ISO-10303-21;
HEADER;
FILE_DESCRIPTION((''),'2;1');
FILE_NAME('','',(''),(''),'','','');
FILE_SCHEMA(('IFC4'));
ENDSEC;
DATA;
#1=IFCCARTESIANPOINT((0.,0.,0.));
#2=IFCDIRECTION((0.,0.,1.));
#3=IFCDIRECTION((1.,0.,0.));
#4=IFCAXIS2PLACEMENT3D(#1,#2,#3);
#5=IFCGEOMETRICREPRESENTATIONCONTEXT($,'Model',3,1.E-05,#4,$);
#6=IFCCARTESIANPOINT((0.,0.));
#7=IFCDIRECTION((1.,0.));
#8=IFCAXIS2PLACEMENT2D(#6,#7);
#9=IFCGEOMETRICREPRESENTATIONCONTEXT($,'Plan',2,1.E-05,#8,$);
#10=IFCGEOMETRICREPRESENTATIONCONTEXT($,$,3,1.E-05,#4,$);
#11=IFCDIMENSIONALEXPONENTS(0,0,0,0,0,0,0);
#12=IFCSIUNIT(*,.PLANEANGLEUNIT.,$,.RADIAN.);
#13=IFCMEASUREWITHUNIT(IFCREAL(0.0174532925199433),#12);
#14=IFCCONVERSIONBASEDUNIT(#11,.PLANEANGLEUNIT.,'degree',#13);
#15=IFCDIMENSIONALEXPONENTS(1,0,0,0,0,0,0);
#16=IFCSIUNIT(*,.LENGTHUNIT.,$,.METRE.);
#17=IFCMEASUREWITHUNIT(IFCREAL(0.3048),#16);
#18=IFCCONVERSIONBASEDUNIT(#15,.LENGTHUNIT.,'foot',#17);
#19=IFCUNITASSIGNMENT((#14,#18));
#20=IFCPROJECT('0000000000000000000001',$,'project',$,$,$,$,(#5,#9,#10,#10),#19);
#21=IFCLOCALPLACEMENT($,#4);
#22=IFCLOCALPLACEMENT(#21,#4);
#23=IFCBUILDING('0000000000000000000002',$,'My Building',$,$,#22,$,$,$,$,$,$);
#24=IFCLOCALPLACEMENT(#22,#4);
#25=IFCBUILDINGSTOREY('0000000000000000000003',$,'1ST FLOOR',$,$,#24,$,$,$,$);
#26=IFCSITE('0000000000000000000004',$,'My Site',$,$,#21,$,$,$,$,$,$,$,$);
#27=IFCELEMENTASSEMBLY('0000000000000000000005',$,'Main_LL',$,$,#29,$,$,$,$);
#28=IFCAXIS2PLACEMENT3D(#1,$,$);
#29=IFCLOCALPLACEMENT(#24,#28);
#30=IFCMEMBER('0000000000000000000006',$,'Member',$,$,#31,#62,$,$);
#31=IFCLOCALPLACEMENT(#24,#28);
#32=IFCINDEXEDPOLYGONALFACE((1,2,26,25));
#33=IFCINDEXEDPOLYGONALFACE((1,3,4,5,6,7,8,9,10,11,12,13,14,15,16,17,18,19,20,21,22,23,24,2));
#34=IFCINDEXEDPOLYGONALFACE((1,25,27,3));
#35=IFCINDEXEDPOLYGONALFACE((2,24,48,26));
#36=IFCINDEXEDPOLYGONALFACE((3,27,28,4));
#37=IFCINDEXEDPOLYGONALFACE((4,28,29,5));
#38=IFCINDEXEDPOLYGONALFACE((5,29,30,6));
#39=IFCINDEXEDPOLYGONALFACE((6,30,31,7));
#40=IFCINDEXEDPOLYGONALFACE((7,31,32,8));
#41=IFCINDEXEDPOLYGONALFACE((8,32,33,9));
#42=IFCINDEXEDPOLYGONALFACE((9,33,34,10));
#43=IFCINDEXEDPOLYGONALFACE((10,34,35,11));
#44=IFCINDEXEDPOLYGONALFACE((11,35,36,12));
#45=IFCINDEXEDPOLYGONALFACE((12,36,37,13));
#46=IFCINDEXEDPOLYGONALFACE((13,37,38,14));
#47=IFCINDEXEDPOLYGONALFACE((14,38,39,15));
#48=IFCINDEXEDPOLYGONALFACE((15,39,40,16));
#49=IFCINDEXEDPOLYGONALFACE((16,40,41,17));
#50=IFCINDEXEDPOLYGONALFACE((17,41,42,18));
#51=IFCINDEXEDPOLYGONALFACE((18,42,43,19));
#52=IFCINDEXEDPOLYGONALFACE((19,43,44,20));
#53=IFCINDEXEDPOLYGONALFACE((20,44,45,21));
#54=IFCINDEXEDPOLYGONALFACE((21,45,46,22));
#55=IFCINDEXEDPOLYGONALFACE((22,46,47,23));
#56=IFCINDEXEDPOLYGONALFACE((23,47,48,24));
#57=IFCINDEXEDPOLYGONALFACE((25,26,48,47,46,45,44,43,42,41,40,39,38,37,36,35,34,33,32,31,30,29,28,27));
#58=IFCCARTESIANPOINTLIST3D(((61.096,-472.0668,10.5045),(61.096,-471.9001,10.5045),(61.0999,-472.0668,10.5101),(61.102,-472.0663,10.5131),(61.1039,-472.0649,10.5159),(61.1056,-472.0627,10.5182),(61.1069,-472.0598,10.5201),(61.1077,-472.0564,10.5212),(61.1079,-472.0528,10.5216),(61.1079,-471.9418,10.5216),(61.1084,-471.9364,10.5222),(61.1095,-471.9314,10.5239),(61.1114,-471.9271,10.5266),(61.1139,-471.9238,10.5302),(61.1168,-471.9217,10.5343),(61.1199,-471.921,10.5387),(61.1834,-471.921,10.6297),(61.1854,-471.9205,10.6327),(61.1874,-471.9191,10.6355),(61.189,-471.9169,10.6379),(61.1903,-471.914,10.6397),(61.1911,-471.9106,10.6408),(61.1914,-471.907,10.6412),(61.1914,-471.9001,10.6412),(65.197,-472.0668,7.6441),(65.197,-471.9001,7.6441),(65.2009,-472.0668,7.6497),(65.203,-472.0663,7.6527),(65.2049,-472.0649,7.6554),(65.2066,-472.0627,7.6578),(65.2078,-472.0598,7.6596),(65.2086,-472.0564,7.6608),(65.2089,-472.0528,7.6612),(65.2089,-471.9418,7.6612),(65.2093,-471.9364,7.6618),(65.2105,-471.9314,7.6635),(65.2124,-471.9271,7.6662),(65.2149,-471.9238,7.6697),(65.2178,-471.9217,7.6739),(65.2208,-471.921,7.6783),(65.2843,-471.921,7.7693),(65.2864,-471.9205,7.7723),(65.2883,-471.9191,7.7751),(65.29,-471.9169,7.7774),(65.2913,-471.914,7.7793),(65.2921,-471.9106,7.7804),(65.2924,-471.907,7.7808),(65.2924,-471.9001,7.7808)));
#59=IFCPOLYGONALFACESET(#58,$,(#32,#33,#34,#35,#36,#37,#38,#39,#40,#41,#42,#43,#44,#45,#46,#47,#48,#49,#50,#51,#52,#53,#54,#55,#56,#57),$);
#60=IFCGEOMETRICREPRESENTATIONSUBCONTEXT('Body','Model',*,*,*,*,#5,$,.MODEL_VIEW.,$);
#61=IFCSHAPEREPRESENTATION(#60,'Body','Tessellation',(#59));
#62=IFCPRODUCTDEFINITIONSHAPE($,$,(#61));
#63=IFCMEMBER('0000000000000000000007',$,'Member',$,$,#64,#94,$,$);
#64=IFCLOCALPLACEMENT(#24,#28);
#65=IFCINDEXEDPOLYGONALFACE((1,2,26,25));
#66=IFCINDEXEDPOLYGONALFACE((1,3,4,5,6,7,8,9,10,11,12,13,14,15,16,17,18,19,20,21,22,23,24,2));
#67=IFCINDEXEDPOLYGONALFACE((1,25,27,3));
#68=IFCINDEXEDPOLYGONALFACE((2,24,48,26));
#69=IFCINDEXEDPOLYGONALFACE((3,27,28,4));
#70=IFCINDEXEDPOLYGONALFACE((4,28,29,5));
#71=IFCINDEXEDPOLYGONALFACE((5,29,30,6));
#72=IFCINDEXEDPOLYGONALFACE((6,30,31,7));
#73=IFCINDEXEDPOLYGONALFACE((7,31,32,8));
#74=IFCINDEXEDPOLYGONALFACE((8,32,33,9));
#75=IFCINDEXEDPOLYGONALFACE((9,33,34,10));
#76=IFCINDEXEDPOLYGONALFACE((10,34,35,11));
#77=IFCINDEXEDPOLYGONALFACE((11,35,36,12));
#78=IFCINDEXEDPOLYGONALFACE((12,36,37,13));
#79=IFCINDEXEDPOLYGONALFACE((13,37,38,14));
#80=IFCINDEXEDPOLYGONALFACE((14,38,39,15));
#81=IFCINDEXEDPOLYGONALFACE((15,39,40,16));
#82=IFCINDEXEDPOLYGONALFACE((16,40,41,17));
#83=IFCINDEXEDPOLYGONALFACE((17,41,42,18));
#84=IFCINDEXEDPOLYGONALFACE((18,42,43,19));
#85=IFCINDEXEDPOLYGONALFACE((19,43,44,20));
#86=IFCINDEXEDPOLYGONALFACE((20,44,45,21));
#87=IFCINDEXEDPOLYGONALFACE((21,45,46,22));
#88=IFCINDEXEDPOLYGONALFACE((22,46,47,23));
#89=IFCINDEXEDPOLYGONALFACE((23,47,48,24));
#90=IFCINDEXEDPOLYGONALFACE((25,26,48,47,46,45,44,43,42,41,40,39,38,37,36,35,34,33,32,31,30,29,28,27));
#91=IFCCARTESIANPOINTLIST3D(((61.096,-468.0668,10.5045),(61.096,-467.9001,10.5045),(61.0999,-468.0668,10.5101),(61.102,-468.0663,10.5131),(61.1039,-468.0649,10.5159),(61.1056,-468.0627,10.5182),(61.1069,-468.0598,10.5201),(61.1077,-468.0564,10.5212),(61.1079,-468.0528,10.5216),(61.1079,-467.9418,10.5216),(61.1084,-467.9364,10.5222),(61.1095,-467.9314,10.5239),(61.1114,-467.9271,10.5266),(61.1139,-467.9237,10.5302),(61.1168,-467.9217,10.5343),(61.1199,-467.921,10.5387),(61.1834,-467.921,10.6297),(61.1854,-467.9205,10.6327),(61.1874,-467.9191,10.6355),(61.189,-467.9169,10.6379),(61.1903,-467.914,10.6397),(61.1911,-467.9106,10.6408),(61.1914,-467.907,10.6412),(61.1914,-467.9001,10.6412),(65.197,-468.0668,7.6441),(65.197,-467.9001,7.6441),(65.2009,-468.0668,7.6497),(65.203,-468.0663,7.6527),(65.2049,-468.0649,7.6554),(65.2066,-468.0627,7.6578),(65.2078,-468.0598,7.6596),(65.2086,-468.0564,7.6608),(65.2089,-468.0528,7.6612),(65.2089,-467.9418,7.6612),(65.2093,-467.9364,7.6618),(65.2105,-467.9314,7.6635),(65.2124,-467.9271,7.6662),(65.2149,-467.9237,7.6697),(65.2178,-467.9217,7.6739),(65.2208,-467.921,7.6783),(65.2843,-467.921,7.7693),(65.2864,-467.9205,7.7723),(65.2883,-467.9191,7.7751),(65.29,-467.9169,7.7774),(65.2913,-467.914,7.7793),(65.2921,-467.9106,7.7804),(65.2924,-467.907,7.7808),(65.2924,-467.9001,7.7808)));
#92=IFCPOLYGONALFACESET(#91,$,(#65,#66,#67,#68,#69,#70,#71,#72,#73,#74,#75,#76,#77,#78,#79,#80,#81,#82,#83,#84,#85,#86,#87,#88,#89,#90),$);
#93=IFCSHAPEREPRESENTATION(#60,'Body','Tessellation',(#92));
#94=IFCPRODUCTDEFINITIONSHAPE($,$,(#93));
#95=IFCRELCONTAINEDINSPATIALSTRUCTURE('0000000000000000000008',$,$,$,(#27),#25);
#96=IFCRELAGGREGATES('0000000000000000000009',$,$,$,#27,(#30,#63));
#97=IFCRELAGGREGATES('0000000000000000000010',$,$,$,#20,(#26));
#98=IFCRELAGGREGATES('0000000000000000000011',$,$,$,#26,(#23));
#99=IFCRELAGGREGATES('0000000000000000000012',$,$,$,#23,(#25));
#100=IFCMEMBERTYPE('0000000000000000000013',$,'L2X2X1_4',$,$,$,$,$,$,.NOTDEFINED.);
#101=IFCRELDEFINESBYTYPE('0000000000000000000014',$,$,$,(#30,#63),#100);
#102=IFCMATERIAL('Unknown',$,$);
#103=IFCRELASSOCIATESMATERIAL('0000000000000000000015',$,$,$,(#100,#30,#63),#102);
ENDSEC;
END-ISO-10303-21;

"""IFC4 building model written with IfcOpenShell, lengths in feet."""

from ifc_helpers import new_model, entity, si_unit, converted_unit, frame, origin_with_axes, origin_2d_with_axis, place, context, subcontext, project, spatial, l_section, extrude, material, material_profile, profile_set, profile_usage, type_object, element, aggregate, save


model = new_model("IFC4")

# Units and contexts
model_context = context("Model", 3, precision=1e-05, world=origin_with_axes())
plan_context = context("Plan", 2, precision=1e-05, world=origin_2d_with_axis())
context_of_model = context(None, 3, precision=1e-05, world=origin_with_axes())
body_context = subcontext(model_context, "Body", "Model", "MODEL_VIEW")
ifc_project = project(units=[converted_unit("PLANEANGLEUNIT", "degree", entity("IfcReal", 0.0174532925199433), si_unit("PLANEANGLEUNIT", "RADIAN"), dimensions=[0, 0, 0, 0, 0, 0, 0]), converted_unit("LENGTHUNIT", "foot", entity("IfcReal", 0.3048), si_unit("LENGTHUNIT", "METRE"), dimensions=[1, 0, 0, 0, 0, 0, 0])], contexts=[model_context, plan_context, context_of_model, context_of_model])

# Site, building, storey
site_placement = place(None, origin_with_axes())
site = spatial("IfcSite", under=ifc_project, at=site_placement, Name="My Site")
building_placement = place(site_placement, origin_with_axes())
building = spatial("IfcBuilding", under=site, at=building_placement, Name="My Building")
storey_placement = place(building_placement, origin_with_axes())
storey = spatial("IfcBuildingStorey", under=building, at=storey_placement, Name="1ST FLOOR")

# Element assembly, members
assembly_placement = place(storey_placement, origin_with_axes())
assembly = element("IfcElementAssembly", 1, at=assembly_placement, inside=storey, Name="Main_LL")
ifc_material_1 = material(Name="Unknown")
ifc_material_profile_1 = material_profile(ifc_material_1, l_section(Depth=0.1667, Width=0.1667, Thickness=0.0208, FilletRadius=0.0208, EdgeRadius=0.014))
ifc_profile_set_1 = profile_set([ifc_material_profile_1])
ifc_profile_usage_1 = profile_usage(ifc_profile_set_1, cardinal=5)
member_type = type_object("IfcMemberType", Name="L2X2X1_4", PredefinedType="NOTDEFINED", material=ifc_profile_set_1)
member_1_placement = place(assembly_placement, frame((65.2447, -471.9835, 7.7124), z_axis=(-0.820194, 0.0, 0.572085), x_axis=(0.0, -1.0, 0.0)))
member_1 = element("IfcMember", 2, at=member_1_placement, type_object=member_type, material=ifc_profile_usage_1, Name="Member", context=body_context, shape_type="SweptSolid", body=[
    extrude(l_section(Depth=0.1667, Width=0.1667, Thickness=0.0208, FilletRadius=0.0208, EdgeRadius=0.014), origin_with_axes(), (0.0, 0.0, 1.0), 5.0),
])
ifc_profile_usage_2 = profile_usage(ifc_profile_set_1, cardinal=5)
member_2_placement = place(assembly_placement, frame((65.2447, -467.9835, 7.7124), z_axis=(-0.820194, 0.0, 0.572085), x_axis=(0.0, -1.0, 0.0)))
member_2 = element("IfcMember", 3, at=member_2_placement, type_object=member_type, material=ifc_profile_usage_2, Name="Member", context=body_context, shape_type="SweptSolid", body=[
    extrude(l_section(Depth=0.1667, Width=0.1667, Thickness=0.0208, FilletRadius=0.0208, EdgeRadius=0.014), origin_with_axes(), (0.0, 0.0, 1.0), 5.0),
])
aggregate(assembly, [member_1, member_2])

save(model, "model.ifc")
